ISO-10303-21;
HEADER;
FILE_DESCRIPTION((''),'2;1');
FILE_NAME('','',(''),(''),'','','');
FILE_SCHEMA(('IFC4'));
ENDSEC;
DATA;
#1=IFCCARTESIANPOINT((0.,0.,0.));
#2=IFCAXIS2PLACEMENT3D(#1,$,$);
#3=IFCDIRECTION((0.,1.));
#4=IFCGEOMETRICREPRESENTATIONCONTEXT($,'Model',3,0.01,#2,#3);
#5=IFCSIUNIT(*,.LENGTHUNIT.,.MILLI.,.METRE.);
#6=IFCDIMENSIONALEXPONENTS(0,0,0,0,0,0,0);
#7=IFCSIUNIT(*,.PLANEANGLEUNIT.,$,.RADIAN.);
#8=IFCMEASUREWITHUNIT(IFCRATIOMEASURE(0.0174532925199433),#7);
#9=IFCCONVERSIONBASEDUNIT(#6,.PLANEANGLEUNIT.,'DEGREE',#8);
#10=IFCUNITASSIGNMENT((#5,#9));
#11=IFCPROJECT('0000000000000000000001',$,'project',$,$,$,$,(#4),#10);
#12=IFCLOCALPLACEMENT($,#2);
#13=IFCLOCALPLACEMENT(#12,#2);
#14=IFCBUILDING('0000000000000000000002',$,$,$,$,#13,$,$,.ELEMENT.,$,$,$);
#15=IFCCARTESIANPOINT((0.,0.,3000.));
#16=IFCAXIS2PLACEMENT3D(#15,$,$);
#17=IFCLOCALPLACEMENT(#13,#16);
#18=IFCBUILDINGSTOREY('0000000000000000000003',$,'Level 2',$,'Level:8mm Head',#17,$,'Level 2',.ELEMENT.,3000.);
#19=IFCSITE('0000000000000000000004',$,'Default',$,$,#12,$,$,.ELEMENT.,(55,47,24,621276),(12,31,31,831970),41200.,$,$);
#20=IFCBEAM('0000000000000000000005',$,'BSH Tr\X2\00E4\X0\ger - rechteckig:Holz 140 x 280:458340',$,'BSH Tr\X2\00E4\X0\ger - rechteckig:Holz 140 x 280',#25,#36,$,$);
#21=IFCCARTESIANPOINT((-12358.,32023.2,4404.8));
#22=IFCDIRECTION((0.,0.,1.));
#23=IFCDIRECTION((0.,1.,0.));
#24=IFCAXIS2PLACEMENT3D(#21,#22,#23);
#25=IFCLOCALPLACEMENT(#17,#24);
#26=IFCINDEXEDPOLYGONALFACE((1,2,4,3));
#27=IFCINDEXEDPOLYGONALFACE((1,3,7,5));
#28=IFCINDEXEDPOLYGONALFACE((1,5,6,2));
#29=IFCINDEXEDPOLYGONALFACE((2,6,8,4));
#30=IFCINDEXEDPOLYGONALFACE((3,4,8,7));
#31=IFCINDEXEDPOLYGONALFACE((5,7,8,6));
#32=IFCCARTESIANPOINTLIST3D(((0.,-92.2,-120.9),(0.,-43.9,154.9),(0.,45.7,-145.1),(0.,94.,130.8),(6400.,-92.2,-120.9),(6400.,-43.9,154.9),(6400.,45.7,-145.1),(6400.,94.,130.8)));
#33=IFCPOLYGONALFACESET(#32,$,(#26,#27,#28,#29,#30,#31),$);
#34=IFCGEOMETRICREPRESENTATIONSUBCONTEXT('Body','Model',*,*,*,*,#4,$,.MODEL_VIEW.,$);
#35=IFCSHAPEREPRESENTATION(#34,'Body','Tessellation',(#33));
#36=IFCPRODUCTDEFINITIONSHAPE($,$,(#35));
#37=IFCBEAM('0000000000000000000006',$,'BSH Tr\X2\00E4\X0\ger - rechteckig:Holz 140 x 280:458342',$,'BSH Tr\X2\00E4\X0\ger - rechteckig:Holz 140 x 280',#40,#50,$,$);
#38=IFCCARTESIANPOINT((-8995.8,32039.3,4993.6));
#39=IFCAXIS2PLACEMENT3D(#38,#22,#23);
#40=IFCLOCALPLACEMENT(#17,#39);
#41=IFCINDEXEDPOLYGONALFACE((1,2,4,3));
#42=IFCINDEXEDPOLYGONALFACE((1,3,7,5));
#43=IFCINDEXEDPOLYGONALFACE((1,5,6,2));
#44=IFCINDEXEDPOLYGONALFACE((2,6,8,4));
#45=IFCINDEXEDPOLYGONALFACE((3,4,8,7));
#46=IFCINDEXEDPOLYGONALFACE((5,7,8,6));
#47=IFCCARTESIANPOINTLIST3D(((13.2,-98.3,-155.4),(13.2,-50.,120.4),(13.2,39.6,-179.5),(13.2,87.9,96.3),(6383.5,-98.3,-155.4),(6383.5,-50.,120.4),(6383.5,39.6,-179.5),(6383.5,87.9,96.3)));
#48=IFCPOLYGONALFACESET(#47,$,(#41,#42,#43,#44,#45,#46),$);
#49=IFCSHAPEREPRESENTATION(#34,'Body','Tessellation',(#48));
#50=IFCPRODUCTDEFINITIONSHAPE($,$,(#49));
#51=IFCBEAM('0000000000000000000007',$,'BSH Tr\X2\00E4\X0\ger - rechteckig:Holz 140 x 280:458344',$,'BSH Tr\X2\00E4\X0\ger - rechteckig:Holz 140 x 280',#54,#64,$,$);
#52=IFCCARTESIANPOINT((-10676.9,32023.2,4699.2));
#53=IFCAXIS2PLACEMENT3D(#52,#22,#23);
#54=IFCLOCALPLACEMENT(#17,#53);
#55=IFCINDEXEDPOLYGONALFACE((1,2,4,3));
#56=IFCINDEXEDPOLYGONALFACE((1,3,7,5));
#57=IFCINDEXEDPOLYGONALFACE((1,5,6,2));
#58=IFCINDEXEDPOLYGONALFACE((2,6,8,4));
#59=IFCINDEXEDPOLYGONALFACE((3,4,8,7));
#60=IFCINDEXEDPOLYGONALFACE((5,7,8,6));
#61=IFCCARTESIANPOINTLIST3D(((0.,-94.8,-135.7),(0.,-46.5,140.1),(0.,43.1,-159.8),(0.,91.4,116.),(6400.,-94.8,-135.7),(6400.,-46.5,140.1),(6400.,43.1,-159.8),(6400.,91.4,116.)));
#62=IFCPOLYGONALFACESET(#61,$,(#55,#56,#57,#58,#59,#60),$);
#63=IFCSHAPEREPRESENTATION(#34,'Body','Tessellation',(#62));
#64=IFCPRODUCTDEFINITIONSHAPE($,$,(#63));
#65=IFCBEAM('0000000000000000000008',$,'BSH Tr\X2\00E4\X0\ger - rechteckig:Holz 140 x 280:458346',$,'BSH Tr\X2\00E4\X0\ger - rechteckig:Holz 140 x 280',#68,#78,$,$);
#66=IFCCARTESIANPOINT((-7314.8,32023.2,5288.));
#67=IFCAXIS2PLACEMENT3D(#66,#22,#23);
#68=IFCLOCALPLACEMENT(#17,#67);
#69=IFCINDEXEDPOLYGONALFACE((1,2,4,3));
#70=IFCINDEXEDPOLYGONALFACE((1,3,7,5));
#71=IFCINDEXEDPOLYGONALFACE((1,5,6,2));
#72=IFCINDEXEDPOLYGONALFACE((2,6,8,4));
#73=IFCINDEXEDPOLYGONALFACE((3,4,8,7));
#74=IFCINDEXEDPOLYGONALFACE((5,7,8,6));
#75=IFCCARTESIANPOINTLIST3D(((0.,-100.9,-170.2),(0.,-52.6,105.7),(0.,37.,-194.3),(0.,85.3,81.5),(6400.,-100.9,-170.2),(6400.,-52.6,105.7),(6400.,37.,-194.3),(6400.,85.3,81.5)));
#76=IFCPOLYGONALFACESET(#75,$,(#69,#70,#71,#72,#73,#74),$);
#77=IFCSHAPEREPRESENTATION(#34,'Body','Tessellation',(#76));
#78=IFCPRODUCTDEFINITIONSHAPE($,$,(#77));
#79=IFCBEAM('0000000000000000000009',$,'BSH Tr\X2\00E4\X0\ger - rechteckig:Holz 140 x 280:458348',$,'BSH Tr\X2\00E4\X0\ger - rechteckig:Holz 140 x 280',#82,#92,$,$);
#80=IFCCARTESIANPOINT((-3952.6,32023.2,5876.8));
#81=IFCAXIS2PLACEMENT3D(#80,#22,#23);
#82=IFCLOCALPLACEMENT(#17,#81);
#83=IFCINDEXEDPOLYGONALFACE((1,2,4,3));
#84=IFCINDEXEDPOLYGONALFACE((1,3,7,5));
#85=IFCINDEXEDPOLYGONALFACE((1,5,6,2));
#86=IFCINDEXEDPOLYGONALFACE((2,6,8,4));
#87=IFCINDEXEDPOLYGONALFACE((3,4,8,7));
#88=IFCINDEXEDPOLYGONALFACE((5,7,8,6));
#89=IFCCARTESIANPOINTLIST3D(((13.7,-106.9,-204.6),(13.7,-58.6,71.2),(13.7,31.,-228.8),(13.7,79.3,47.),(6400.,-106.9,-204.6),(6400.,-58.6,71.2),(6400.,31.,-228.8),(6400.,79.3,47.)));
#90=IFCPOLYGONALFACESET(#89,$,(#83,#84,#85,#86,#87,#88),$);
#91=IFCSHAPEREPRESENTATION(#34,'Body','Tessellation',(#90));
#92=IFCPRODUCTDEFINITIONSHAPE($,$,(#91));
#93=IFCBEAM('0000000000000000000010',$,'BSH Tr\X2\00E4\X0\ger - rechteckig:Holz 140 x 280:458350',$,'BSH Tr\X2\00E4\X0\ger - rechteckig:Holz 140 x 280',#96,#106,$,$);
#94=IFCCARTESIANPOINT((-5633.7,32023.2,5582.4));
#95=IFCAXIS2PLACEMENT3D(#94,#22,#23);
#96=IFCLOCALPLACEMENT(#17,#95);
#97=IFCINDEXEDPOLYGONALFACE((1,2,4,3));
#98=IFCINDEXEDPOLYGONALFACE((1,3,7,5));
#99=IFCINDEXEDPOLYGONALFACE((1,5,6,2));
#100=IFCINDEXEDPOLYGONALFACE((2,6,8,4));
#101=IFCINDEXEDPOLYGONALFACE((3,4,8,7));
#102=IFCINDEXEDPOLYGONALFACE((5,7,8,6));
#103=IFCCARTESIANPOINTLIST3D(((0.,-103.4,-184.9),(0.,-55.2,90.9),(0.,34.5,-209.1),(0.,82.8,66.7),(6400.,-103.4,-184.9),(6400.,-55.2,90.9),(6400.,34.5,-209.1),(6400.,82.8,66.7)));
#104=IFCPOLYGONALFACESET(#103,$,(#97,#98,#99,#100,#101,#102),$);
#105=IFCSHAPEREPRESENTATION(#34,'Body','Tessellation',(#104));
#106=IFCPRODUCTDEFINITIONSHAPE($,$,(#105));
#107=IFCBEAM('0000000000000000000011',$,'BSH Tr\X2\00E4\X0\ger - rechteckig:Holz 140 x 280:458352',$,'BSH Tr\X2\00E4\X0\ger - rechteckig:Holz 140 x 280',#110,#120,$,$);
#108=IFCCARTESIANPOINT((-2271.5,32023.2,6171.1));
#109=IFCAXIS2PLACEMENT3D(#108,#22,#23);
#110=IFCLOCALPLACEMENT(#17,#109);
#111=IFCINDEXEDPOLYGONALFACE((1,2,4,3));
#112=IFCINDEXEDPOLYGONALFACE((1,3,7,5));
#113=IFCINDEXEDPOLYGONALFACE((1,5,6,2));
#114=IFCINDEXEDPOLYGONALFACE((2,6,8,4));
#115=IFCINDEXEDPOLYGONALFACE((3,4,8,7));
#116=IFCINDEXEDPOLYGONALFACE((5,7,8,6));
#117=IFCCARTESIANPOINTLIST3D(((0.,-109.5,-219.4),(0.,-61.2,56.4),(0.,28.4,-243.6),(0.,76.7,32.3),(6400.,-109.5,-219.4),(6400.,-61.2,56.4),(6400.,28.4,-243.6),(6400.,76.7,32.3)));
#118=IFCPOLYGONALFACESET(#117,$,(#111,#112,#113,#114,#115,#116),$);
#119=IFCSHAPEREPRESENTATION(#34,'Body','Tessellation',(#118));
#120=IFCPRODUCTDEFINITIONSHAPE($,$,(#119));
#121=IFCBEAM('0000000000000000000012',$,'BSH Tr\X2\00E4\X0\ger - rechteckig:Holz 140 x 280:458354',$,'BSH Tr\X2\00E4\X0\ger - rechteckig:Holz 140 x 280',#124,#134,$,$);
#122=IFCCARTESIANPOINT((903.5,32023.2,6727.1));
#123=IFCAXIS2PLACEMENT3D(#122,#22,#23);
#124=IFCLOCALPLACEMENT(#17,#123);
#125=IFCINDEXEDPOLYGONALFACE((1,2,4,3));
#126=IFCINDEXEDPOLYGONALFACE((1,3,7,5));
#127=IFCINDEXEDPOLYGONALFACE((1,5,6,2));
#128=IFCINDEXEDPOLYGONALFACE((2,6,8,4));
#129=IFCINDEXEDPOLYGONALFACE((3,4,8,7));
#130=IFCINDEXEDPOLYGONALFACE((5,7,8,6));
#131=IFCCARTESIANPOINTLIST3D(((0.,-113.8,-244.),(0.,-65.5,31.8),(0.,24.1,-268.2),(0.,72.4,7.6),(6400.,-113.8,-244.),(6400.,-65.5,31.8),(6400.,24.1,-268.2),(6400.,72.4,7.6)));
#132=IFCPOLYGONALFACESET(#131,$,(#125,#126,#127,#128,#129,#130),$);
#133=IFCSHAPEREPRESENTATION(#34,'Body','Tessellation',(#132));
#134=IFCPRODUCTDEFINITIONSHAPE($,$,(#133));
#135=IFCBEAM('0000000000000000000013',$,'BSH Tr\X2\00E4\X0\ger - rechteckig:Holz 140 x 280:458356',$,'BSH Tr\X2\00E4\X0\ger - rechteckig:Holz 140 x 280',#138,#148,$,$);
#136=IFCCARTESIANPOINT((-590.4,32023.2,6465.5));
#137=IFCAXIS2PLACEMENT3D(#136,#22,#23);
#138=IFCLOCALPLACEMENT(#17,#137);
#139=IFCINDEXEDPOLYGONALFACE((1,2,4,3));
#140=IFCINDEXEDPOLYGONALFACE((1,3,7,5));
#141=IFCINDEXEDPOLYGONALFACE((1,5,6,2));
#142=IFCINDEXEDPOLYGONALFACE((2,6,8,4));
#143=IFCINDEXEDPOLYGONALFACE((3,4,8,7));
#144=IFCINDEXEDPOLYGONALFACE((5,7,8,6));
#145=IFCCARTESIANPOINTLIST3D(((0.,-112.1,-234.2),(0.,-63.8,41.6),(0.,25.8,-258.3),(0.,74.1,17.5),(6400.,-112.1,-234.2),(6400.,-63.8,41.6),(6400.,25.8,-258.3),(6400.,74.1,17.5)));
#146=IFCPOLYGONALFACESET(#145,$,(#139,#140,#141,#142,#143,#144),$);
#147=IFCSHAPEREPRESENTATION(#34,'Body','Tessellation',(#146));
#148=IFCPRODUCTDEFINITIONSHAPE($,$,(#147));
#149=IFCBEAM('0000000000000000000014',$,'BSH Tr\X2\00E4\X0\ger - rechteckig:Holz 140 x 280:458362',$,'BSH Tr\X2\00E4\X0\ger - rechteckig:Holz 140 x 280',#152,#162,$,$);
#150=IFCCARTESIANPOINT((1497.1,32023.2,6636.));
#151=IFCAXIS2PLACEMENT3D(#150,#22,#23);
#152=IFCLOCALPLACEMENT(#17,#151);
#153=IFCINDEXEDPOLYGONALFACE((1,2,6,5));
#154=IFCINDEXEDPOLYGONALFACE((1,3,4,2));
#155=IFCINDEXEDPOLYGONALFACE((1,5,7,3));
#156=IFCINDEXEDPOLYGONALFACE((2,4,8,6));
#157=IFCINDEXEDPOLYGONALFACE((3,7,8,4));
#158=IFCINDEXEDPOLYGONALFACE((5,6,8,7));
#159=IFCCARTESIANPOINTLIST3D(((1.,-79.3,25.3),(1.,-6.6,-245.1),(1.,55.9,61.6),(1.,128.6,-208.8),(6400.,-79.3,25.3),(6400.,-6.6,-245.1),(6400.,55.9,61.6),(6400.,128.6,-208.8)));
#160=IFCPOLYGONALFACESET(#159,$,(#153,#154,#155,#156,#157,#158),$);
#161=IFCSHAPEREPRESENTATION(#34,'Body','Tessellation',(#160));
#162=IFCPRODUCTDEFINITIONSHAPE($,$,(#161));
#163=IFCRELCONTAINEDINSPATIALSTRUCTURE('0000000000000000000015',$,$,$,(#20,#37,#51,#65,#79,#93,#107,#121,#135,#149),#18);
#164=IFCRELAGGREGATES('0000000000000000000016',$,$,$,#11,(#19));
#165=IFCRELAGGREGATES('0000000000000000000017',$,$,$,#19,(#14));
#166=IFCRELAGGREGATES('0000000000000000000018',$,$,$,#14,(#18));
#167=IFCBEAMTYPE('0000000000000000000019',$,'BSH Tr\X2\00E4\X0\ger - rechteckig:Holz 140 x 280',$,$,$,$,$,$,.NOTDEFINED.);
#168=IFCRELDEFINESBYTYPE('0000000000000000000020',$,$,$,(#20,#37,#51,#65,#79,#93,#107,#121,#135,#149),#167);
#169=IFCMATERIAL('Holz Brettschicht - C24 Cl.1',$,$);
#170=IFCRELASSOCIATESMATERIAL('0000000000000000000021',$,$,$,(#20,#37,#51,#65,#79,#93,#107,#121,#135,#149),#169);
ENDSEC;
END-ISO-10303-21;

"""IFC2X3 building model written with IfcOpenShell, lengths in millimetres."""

from ifc_helpers import new_model, entity, si_unit, converted_unit, direction, frame, frame_2d, origin, origin_2d_with_axis, place, context, subcontext, project, spatial, rectangle, extrude, material, type_object, element, save


model = new_model("IFC2X3")

# Units and contexts
model_context = context("Model", 3, precision=0.01, world=origin(), true_north=direction((0.0, 1.0)))
body_context = subcontext(model_context, "Body", "Model", "MODEL_VIEW")
ifc_project = project(units=[si_unit("LENGTHUNIT", "METRE", prefix="MILLI"), converted_unit("PLANEANGLEUNIT", "DEGREE", entity("IfcRatioMeasure", 0.0174532925199433), si_unit("PLANEANGLEUNIT", "RADIAN"), dimensions=[0, 0, 0, 0, 0, 0, 0])], contexts=[model_context])

# Site, building, storey
site_placement = place(None, origin())
site = spatial("IfcSite", under=ifc_project, at=site_placement, Name="Default", CompositionType="ELEMENT", RefLatitude=(55, 47, 24, 621276), RefLongitude=(12, 31, 31, 831970), RefElevation=41200.0)
building_placement = place(site_placement, origin())
building = spatial("IfcBuilding", under=site, at=building_placement, CompositionType="ELEMENT")
storey_placement = place(building_placement, frame((0.0, 0.0, 3000.0)))
storey = spatial("IfcBuildingStorey", under=building, at=storey_placement, Name="Level 2", ObjectType="Level:8mm Head", LongName="Level 2", CompositionType="ELEMENT", Elevation=3000.0)

# Shared definitions
ifc_material_1 = material(Name="Holz Brettschicht - C24 Cl.1")

# Beams
beam_type_1 = type_object("IfcBeamType", Name="BSH Träger - rechteckig:Holz 140 x 280", PredefinedType="NOTDEFINED")
beam_1_placement = place(storey_placement, frame((-12358.0, 32023.2, 4404.8), z_axis=(0.0, 0.0, 1.0), x_axis=(0.0, 1.0, 0.0)))
element("IfcBeam", 1, at=beam_1_placement, inside=storey, type_object=beam_type_1, material=ifc_material_1, Name="BSH Träger - rechteckig:Holz 140 x 280:458340", ObjectType="BSH Träger - rechteckig:Holz 140 x 280", context=body_context, shape_type="SweptSolid", body=[
    extrude(rectangle(XDim=280.0, YDim=140.0, at=origin_2d_with_axis()), frame((0.0, 0.9, 4.9), z_axis=(1.0, 0.0, 0.0), x_axis=(0.0, 0.172491, 0.985011)), (0.0, 0.0, 1.0), 6400.0),
])
beam_2_placement = place(storey_placement, frame((-8995.8, 32039.3, 4993.6), z_axis=(0.0, 0.0, 1.0), x_axis=(0.0, 1.0, 0.0)))
element("IfcBeam", 2, at=beam_2_placement, inside=storey, type_object=beam_type_1, material=ifc_material_1, Name="BSH Träger - rechteckig:Holz 140 x 280:458342", ObjectType="BSH Träger - rechteckig:Holz 140 x 280", context=body_context, shape_type="SweptSolid", body=[
    extrude(rectangle(XDim=280.0, YDim=140.0, at=origin_2d_with_axis()), frame((13.2, -5.2, -29.6), z_axis=(1.0, 0.0, 0.0), x_axis=(0.0, 0.172491, 0.985011)), (0.0, 0.0, 1.0), 6370.3),
])
beam_3_placement = place(storey_placement, frame((-10676.9, 32023.2, 4699.2), z_axis=(0.0, 0.0, 1.0), x_axis=(0.0, 1.0, 0.0)))
element("IfcBeam", 3, at=beam_3_placement, inside=storey, type_object=beam_type_1, material=ifc_material_1, Name="BSH Träger - rechteckig:Holz 140 x 280:458344", ObjectType="BSH Träger - rechteckig:Holz 140 x 280", context=body_context, shape_type="SweptSolid", body=[
    extrude(rectangle(XDim=280.0, YDim=140.0, at=origin_2d_with_axis()), frame((0.0, -1.7, -9.9), z_axis=(1.0, 0.0, 0.0), x_axis=(0.0, 0.172491, 0.985011)), (0.0, 0.0, 1.0), 6400.0),
])
beam_4_placement = place(storey_placement, frame((-7314.8, 32023.2, 5288.0), z_axis=(0.0, 0.0, 1.0), x_axis=(0.0, 1.0, 0.0)))
element("IfcBeam", 4, at=beam_4_placement, inside=storey, type_object=beam_type_1, material=ifc_material_1, Name="BSH Träger - rechteckig:Holz 140 x 280:458346", ObjectType="BSH Träger - rechteckig:Holz 140 x 280", context=body_context, shape_type="SweptSolid", body=[
    extrude(rectangle(XDim=280.0, YDim=140.0, at=frame_2d((0.0, 0.0), x_axis=(1.0, 0.0))), frame((0.0, -7.8, -44.3), z_axis=(1.0, 0.0, 0.0), x_axis=(0.0, 0.172491, 0.985011)), (0.0, 0.0, 1.0), 6400.0),
])
beam_5_placement = place(storey_placement, frame((-3952.6, 32023.2, 5876.8), z_axis=(0.0, 0.0, 1.0), x_axis=(0.0, 1.0, 0.0)))
element("IfcBeam", 5, at=beam_5_placement, inside=storey, type_object=beam_type_1, material=ifc_material_1, Name="BSH Träger - rechteckig:Holz 140 x 280:458348", ObjectType="BSH Träger - rechteckig:Holz 140 x 280", context=body_context, shape_type="SweptSolid", body=[
    extrude(rectangle(XDim=280.0, YDim=140.0, at=origin_2d_with_axis()), frame((13.7, -13.8, -78.8), z_axis=(1.0, 0.0, 0.0), x_axis=(0.0, 0.172491, 0.985011)), (0.0, 0.0, 1.0), 6386.3),
])
beam_6_placement = place(storey_placement, frame((-5633.7, 32023.2, 5582.4), z_axis=(0.0, 0.0, 1.0), x_axis=(0.0, 1.0, 0.0)))
element("IfcBeam", 6, at=beam_6_placement, inside=storey, type_object=beam_type_1, material=ifc_material_1, Name="BSH Träger - rechteckig:Holz 140 x 280:458350", ObjectType="BSH Träger - rechteckig:Holz 140 x 280", context=body_context, shape_type="SweptSolid", body=[
    extrude(rectangle(XDim=280.0, YDim=140.0, at=origin_2d_with_axis()), frame((0.0, -10.3, -59.1), z_axis=(1.0, 0.0, 0.0), x_axis=(0.0, 0.172491, 0.985011)), (0.0, 0.0, 1.0), 6400.0),
])
beam_7_placement = place(storey_placement, frame((-2271.5, 32023.2, 6171.1), z_axis=(0.0, 0.0, 1.0), x_axis=(0.0, 1.0, 0.0)))
element("IfcBeam", 7, at=beam_7_placement, inside=storey, type_object=beam_type_1, material=ifc_material_1, Name="BSH Träger - rechteckig:Holz 140 x 280:458352", ObjectType="BSH Träger - rechteckig:Holz 140 x 280", context=body_context, shape_type="SweptSolid", body=[
    extrude(rectangle(XDim=280.0, YDim=140.0, at=origin_2d_with_axis()), frame((0.0, -16.4, -93.6), z_axis=(1.0, 0.0, 0.0), x_axis=(0.0, 0.172491, 0.985011)), (0.0, 0.0, 1.0), 6400.0),
])
beam_8_placement = place(storey_placement, frame((903.5, 32023.2, 6727.1), z_axis=(0.0, 0.0, 1.0), x_axis=(0.0, 1.0, 0.0)))
element("IfcBeam", 8, at=beam_8_placement, inside=storey, type_object=beam_type_1, material=ifc_material_1, Name="BSH Träger - rechteckig:Holz 140 x 280:458354", ObjectType="BSH Träger - rechteckig:Holz 140 x 280", context=body_context, shape_type="SweptSolid", body=[
    extrude(rectangle(XDim=280.0, YDim=140.0, at=frame_2d((0.0, 0.0), x_axis=(1.0, 0.0))), frame((0.0, -20.7, -118.2), z_axis=(1.0, 0.0, 0.0), x_axis=(0.0, 0.172491, 0.985011)), (0.0, 0.0, 1.0), 6400.0),
])
beam_9_placement = place(storey_placement, frame((-590.4, 32023.2, 6465.5), z_axis=(0.0, 0.0, 1.0), x_axis=(0.0, 1.0, 0.0)))
element("IfcBeam", 9, at=beam_9_placement, inside=storey, type_object=beam_type_1, material=ifc_material_1, Name="BSH Träger - rechteckig:Holz 140 x 280:458356", ObjectType="BSH Träger - rechteckig:Holz 140 x 280", context=body_context, shape_type="SweptSolid", body=[
    extrude(rectangle(XDim=280.0, YDim=140.0, at=frame_2d((0.0, 0.0), x_axis=(1.0, 0.0))), frame((0.0, -19.0, -108.4), z_axis=(1.0, 0.0, 0.0), x_axis=(0.0, 0.172491, 0.985011)), (0.0, 0.0, 1.0), 6400.0),
])
beam_10_placement = place(storey_placement, frame((1497.1, 32023.2, 6636.0), z_axis=(0.0, 0.0, 1.0), x_axis=(0.0, 1.0, 0.0)))
element("IfcBeam", 10, at=beam_10_placement, inside=storey, type_object=beam_type_1, material=ifc_material_1, Name="BSH Träger - rechteckig:Holz 140 x 280:458362", ObjectType="BSH Träger - rechteckig:Holz 140 x 280", context=body_context, shape_type="SweptSolid", body=[
    extrude(rectangle(XDim=280.0, YDim=140.0, at=frame_2d((0.0, 0.0), x_axis=(1.0, 0.0))), frame((1.0, 24.7, -91.7), z_axis=(1.0, 0.0, 0.0), x_axis=(0.0, -0.259528, 0.965735)), (0.0, 0.0, 1.0), 6399.0),
])

save(model, "model.ifc")
